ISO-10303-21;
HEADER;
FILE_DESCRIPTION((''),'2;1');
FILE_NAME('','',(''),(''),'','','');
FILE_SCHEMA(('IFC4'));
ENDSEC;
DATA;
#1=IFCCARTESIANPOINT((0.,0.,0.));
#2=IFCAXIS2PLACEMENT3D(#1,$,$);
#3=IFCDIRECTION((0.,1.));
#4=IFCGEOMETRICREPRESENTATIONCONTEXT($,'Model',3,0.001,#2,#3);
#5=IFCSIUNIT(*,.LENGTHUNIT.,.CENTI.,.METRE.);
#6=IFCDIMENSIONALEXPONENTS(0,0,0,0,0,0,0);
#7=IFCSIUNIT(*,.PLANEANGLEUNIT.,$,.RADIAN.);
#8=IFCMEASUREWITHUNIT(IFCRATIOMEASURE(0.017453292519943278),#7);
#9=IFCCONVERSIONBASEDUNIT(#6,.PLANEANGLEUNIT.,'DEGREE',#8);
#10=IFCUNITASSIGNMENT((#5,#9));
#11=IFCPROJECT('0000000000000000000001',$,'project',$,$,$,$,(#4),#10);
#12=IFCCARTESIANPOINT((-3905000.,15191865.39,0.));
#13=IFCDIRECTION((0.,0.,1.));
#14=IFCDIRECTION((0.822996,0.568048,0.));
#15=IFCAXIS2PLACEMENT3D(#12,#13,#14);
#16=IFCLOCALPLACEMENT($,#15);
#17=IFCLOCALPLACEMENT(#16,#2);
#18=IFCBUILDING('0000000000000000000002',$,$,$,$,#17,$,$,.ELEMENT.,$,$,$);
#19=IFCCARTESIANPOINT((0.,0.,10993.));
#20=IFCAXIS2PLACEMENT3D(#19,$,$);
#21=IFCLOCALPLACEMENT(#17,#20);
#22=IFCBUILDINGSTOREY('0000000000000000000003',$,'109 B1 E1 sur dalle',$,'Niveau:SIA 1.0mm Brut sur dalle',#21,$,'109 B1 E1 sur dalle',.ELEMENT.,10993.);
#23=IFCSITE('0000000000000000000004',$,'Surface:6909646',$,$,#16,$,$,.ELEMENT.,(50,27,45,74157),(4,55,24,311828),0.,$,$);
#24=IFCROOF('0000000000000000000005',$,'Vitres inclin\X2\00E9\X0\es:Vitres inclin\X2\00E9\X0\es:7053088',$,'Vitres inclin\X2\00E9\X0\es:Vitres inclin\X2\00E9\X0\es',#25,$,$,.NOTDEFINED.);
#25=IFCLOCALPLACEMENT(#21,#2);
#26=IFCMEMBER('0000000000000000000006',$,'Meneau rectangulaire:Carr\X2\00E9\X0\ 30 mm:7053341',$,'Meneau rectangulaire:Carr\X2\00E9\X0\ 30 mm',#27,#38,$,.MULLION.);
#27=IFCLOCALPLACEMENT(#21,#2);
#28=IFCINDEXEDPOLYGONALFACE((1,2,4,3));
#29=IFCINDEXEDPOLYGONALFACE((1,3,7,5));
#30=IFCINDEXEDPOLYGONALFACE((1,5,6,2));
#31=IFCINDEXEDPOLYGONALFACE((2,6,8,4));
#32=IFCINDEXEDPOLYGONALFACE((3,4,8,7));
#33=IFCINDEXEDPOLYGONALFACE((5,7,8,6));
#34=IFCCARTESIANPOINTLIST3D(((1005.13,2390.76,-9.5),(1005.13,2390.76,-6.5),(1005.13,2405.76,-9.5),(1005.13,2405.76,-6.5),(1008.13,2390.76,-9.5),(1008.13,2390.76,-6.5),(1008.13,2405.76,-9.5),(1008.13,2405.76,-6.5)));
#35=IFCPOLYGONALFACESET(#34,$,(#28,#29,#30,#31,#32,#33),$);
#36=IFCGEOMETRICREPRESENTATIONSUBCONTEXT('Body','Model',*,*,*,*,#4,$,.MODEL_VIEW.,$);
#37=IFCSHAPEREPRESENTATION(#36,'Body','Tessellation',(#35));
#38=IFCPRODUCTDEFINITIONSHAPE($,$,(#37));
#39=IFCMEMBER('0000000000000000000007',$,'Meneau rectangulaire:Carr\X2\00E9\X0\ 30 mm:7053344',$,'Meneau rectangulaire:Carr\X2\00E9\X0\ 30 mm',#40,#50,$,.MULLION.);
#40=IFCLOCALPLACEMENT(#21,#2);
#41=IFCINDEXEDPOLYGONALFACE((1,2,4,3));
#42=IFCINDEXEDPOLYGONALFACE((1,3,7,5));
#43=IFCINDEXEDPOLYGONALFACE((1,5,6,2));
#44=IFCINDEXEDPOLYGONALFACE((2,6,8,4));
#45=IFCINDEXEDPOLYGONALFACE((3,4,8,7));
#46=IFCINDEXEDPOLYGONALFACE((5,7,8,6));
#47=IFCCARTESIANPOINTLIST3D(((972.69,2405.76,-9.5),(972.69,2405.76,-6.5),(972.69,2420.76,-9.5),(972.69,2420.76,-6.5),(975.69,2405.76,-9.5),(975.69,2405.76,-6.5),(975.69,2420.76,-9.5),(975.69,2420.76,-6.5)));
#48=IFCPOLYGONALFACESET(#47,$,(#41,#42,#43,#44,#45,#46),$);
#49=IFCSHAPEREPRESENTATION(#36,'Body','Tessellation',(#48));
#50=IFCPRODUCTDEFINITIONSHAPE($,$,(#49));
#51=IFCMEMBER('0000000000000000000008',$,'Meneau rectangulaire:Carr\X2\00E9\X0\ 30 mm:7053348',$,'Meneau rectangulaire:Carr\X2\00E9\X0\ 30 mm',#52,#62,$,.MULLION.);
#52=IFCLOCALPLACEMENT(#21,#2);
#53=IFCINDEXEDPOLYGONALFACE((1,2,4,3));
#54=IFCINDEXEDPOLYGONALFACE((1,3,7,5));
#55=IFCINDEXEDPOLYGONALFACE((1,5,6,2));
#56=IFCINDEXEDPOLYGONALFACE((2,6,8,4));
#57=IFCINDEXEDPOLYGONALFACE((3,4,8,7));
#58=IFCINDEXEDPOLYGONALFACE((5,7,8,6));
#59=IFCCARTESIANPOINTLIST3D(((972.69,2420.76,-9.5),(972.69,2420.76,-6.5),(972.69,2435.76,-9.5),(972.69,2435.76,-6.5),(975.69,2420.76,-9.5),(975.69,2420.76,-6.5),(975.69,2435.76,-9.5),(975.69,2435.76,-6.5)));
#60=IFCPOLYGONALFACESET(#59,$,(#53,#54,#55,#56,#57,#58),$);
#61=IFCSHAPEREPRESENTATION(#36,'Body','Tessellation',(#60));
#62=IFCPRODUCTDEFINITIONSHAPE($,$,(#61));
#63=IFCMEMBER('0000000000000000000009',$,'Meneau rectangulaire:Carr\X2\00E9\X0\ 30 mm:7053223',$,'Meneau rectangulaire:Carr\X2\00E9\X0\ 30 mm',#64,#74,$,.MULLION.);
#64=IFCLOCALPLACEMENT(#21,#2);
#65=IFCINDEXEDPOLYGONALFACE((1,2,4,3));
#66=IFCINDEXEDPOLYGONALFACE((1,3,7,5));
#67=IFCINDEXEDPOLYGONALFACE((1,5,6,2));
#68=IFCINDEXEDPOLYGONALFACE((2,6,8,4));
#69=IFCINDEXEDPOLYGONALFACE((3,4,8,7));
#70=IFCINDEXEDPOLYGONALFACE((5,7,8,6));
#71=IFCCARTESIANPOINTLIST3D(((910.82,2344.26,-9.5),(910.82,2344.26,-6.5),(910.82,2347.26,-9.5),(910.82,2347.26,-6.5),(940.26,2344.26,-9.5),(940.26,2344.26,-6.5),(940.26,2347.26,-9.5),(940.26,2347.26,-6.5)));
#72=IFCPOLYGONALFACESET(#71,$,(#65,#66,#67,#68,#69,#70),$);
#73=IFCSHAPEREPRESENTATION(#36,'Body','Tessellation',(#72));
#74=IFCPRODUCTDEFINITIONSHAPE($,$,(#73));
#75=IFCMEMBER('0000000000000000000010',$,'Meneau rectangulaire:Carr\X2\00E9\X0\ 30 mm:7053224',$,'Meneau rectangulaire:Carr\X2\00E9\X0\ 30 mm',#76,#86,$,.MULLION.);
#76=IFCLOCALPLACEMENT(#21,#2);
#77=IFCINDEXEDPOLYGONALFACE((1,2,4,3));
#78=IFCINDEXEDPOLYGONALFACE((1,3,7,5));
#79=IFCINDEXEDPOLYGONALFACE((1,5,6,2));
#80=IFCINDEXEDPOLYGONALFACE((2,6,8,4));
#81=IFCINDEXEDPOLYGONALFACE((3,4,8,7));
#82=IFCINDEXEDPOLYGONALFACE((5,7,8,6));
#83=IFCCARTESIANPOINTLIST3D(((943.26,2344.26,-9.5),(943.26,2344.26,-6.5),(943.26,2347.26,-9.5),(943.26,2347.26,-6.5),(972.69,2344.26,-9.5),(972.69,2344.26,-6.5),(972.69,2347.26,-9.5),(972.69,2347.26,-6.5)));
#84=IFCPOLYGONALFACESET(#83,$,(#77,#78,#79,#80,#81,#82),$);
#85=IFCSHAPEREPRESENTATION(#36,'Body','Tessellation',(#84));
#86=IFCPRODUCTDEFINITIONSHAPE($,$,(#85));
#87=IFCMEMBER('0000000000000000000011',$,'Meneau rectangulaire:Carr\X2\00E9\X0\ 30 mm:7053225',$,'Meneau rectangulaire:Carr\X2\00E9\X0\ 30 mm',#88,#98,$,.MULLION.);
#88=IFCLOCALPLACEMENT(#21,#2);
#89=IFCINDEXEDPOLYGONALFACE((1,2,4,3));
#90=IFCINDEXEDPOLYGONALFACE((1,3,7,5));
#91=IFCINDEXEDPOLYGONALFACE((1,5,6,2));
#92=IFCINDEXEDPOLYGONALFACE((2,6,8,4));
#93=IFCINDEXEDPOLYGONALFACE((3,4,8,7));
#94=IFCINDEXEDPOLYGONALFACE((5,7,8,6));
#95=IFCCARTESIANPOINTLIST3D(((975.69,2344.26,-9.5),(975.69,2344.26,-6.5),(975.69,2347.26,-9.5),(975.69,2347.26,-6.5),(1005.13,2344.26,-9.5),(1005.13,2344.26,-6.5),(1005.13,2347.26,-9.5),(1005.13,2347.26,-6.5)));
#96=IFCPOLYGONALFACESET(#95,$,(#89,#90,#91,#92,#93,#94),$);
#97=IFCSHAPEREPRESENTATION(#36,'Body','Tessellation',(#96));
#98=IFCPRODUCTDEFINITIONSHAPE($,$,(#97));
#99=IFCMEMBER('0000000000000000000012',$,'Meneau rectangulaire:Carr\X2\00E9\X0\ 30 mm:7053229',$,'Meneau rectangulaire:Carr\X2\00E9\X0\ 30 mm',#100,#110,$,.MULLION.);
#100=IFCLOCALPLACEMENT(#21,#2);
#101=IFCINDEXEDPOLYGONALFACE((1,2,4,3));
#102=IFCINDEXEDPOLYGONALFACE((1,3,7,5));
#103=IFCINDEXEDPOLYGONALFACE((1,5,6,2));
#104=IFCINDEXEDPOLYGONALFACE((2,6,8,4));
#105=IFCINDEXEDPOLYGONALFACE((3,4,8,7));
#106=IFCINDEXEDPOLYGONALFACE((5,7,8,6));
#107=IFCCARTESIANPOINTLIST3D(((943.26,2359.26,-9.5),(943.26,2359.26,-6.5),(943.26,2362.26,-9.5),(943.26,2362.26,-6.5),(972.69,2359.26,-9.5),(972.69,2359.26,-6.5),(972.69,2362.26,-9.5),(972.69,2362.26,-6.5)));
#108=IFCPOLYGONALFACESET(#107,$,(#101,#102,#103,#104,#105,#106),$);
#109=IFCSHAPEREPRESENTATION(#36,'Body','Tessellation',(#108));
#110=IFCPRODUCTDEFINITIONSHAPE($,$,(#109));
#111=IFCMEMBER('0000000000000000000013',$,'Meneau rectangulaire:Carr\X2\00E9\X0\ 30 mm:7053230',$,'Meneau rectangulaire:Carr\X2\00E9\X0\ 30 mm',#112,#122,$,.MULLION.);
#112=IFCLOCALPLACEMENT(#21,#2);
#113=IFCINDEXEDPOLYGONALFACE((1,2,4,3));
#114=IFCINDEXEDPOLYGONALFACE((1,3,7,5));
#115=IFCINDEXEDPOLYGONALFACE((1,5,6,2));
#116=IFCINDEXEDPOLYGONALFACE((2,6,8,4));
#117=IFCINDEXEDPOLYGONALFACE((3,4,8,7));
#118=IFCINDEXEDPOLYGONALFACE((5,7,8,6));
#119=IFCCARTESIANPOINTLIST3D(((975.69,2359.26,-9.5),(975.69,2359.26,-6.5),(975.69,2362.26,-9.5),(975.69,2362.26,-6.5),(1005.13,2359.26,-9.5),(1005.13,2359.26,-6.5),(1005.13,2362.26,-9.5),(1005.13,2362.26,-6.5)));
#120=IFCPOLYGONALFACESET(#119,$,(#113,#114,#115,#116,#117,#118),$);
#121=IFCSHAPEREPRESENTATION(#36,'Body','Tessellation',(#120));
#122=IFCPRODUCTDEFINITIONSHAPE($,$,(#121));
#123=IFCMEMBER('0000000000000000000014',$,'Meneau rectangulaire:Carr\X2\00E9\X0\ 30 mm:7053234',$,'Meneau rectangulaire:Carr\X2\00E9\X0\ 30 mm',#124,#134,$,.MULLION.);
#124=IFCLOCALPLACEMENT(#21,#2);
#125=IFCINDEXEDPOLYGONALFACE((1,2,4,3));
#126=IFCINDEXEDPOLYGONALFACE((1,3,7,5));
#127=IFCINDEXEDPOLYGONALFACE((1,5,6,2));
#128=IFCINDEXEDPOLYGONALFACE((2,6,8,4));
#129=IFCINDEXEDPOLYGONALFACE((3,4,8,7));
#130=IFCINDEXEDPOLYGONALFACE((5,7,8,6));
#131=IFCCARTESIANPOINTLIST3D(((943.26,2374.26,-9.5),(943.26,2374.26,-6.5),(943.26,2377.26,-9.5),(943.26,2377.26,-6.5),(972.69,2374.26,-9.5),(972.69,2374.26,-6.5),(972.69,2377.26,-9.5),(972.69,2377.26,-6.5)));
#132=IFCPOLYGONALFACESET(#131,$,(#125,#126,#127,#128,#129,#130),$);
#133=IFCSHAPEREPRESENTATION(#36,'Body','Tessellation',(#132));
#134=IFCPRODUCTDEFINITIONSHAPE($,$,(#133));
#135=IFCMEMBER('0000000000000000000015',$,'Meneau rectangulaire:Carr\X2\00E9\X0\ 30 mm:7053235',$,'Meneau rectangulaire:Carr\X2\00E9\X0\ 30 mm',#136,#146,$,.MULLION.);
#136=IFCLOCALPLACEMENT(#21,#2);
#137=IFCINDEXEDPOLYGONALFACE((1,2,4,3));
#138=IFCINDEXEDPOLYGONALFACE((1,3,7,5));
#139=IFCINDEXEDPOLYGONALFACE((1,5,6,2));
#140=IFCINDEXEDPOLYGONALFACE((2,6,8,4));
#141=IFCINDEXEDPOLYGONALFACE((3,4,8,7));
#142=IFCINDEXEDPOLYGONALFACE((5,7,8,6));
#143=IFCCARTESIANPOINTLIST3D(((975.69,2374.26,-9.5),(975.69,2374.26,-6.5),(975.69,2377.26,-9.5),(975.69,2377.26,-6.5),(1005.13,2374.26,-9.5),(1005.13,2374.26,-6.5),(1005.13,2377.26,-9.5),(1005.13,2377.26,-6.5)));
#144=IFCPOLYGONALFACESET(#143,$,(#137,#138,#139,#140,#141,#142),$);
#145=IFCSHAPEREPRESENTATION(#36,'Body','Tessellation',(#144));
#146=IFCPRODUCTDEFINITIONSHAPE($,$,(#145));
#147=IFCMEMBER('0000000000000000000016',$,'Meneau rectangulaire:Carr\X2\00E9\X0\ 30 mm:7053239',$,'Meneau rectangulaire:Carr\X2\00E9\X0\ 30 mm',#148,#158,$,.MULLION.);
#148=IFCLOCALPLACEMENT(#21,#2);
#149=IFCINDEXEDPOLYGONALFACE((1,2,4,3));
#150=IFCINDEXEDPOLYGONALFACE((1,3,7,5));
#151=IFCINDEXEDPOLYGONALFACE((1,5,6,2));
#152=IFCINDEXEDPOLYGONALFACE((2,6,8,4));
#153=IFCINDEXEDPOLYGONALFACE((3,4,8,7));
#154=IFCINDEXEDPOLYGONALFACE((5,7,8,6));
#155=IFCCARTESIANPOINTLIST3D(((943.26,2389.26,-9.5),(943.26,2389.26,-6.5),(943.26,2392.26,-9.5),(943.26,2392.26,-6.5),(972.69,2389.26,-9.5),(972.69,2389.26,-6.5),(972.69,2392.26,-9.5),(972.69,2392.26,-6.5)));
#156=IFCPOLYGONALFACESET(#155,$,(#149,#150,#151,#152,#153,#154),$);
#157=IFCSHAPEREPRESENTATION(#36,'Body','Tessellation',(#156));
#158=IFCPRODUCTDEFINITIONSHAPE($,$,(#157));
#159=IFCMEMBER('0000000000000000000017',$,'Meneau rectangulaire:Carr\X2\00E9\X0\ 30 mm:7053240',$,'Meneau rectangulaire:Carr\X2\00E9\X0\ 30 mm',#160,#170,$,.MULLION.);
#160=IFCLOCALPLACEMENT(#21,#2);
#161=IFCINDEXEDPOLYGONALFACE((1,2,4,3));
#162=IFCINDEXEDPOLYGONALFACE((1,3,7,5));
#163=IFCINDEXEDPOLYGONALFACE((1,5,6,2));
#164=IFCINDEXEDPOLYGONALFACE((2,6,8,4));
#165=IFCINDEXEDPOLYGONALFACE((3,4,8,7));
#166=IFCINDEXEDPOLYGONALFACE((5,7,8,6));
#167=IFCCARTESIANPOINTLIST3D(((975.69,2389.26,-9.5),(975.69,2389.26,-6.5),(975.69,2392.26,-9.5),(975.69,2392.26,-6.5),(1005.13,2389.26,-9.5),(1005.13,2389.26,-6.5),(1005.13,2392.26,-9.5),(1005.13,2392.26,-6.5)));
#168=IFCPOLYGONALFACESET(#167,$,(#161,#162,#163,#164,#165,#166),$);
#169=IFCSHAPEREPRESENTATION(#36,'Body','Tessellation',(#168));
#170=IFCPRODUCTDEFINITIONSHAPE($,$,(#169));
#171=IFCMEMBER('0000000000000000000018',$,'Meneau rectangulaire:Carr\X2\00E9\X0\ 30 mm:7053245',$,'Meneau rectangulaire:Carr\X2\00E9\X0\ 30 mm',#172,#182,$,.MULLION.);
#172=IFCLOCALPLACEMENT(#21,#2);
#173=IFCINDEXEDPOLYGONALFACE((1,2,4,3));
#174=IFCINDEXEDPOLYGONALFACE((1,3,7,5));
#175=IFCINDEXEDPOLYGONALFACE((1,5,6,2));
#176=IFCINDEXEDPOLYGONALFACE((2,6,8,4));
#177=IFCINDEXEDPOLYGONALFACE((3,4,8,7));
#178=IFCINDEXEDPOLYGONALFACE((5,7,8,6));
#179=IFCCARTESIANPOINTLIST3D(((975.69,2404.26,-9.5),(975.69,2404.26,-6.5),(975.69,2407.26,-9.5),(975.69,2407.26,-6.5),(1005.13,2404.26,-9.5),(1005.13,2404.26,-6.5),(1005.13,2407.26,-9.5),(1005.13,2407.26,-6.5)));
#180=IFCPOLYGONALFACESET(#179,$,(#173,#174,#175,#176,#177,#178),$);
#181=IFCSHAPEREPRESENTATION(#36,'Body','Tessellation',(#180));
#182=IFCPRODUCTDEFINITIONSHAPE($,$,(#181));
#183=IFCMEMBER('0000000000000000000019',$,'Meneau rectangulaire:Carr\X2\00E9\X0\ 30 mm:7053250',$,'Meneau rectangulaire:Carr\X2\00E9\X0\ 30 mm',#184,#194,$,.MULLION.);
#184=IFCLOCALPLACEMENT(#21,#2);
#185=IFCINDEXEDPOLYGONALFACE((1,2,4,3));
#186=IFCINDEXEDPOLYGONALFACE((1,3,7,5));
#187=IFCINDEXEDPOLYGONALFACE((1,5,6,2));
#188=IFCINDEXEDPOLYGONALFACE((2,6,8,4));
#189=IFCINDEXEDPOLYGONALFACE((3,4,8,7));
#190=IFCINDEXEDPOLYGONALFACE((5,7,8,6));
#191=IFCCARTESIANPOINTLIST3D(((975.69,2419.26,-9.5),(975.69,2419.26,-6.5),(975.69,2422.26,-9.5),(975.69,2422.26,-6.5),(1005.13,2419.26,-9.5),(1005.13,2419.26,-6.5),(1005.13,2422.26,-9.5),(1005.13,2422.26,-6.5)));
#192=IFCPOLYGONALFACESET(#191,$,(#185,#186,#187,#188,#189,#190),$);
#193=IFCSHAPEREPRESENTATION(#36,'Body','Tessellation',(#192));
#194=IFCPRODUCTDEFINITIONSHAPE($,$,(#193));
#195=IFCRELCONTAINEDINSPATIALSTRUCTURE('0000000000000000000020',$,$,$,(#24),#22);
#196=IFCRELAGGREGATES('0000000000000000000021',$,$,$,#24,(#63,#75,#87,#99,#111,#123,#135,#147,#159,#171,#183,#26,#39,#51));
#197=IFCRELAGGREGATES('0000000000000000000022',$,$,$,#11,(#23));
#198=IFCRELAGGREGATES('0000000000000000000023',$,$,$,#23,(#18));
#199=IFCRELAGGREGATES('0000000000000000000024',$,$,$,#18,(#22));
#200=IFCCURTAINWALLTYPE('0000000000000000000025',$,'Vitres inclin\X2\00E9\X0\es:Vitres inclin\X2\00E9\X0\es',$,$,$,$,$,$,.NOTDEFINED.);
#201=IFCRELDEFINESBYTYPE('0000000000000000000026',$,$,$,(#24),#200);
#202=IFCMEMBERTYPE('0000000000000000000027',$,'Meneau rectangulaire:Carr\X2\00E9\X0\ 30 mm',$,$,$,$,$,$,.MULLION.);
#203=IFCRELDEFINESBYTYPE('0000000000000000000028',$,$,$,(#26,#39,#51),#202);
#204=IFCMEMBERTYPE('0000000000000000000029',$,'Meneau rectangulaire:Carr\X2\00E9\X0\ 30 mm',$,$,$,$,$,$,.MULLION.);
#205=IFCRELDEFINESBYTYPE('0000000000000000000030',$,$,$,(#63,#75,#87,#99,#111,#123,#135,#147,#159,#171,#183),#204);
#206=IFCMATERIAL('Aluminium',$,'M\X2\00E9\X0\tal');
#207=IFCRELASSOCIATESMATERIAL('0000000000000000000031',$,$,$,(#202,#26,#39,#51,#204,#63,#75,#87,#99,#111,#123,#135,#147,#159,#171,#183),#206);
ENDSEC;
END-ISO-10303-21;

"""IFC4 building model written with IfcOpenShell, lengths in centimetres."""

from ifc_helpers import new_model, entity, si_unit, converted_unit, direction, frame, origin, place, context, subcontext, project, spatial, indexed_curve, outline, extrude, source, transform, mapped, material, type_object, type_shapes, element, aggregate, save


model = new_model("IFC4")

# Units and contexts
model_context = context("Model", 3, precision=0.001, world=origin(), true_north=direction((0.0, 1.0)))
body_context = subcontext(model_context, "Body", "Model", "MODEL_VIEW")
ifc_project = project(units=[si_unit("LENGTHUNIT", "METRE", prefix="CENTI"), converted_unit("PLANEANGLEUNIT", "DEGREE", entity("IfcRatioMeasure", 0.017453292519943278), si_unit("PLANEANGLEUNIT", "RADIAN"), dimensions=[0, 0, 0, 0, 0, 0, 0])], contexts=[model_context])

# Site, building, storey
site_placement = place(None, frame((-3905000.0, 15191865.39, 0.0), z_axis=(0.0, 0.0, 1.0), x_axis=(0.822996, 0.568048, 0.0)))
site = spatial("IfcSite", under=ifc_project, at=site_placement, Name="Surface:6909646", CompositionType="ELEMENT", RefLatitude=(50, 27, 45, 74157), RefLongitude=(4, 55, 24, 311828), RefElevation=0.0)
building_placement = place(site_placement, origin())
building = spatial("IfcBuilding", under=site, at=building_placement, CompositionType="ELEMENT")
storey_placement = place(building_placement, frame((0.0, 0.0, 10993.0)))
storey = spatial("IfcBuildingStorey", under=building, at=storey_placement, Name="109 B1 E1 sur dalle", ObjectType="Niveau:SIA 1.0mm Brut sur dalle", LongName="109 B1 E1 sur dalle", CompositionType="ELEMENT", Elevation=10993.0)

# Roof, members
curtain_wall_type = type_object("IfcCurtainWallType", Name="Vitres inclinées:Vitres inclinées", PredefinedType="NOTDEFINED")
roof_placement = place(storey_placement, frame((0.0, 0.0, -10993.0)))
roof = element("IfcRoof", 1, at=roof_placement, inside=storey, type_object=curtain_wall_type, Name="Vitres inclinées:Vitres inclinées:7053088", ObjectType="Vitres inclinées:Vitres inclinées", PredefinedType="NOTDEFINED")
ifc_material = material(Name="Aluminium", Category="Métal")
member_type_1 = type_object("IfcMemberType", Name="Meneau rectangulaire:Carré 30 mm", PredefinedType="MULLION", material=ifc_material)
shared_shape_1 = source(origin(), body_context, "Body", "SweptSolid", [
    extrude(outline(indexed_curve([(-1.5, -1.5), (1.5, -1.5), (1.5, 1.5), (-1.5, 1.5), (-1.5, -1.5)], self_intersect=False)), frame((0.0, 0.0, -15.0), z_axis=(0.0, 0.0, 1.0), x_axis=(0.0, -1.0, 0.0)), (0.0, 0.0, 1.0), 15.0),
])
type_shapes(member_type_1, [shared_shape_1])
member_1_placement = place(roof_placement, frame((1006.63, 2405.76, 10985.0), z_axis=(0.0, 1.0, 0.0), x_axis=(1.0, 0.0, 0.0)))
member_1 = element("IfcMember", 2, at=member_1_placement, type_object=member_type_1, material=ifc_material, Name="Meneau rectangulaire:Carré 30 mm:7053341", ObjectType="Meneau rectangulaire:Carré 30 mm", PredefinedType="MULLION", context=body_context, shape_type="MappedRepresentation", body=[
    mapped(shared_shape_1, transform((0.0, 0.0, 0.0), scale=1.0)),
])
member_2_placement = place(roof_placement, frame((974.19, 2420.76, 10985.0), z_axis=(0.0, 1.0, 0.0), x_axis=(1.0, 0.0, 0.0)))
member_2 = element("IfcMember", 3, at=member_2_placement, type_object=member_type_1, material=ifc_material, Name="Meneau rectangulaire:Carré 30 mm:7053344", ObjectType="Meneau rectangulaire:Carré 30 mm", PredefinedType="MULLION", context=body_context, shape_type="MappedRepresentation", body=[
    mapped(shared_shape_1, transform((0.0, 0.0, 0.0), scale=1.0)),
])
member_3_placement = place(roof_placement, frame((974.19, 2435.76, 10985.0), z_axis=(0.0, 1.0, 0.0), x_axis=(1.0, 0.0, 0.0)))
member_3 = element("IfcMember", 4, at=member_3_placement, type_object=member_type_1, material=ifc_material, Name="Meneau rectangulaire:Carré 30 mm:7053348", ObjectType="Meneau rectangulaire:Carré 30 mm", PredefinedType="MULLION", context=body_context, shape_type="MappedRepresentation", body=[
    mapped(shared_shape_1, transform((0.0, 0.0, 0.0), scale=1.0)),
])
member_type_2 = type_object("IfcMemberType", Name="Meneau rectangulaire:Carré 30 mm", PredefinedType="MULLION", material=ifc_material)
shared_shape_2 = source(origin(), body_context, "Body", "SweptSolid", [
    extrude(outline(indexed_curve([(-1.5, -1.5), (1.5, -1.5), (1.5, 1.5), (-1.5, 1.5), (-1.5, -1.5)], self_intersect=False)), frame((0.0, 0.0, -29.44), z_axis=(0.0, 0.0, 1.0), x_axis=(0.0, -1.0, 0.0)), (0.0, 0.0, 1.0), 29.44),
])
type_shapes(member_type_2, [shared_shape_2])
member_4_placement = place(roof_placement, frame((910.82, 2345.76, 10985.0), z_axis=(-1.0, 0.0, 0.0), x_axis=(0.0, 1.0, 0.0)))
member_4 = element("IfcMember", 5, at=member_4_placement, type_object=member_type_2, material=ifc_material, Name="Meneau rectangulaire:Carré 30 mm:7053223", ObjectType="Meneau rectangulaire:Carré 30 mm", PredefinedType="MULLION", context=body_context, shape_type="MappedRepresentation", body=[
    mapped(shared_shape_2, transform((0.0, 0.0, 0.0), scale=1.0)),
])
member_5_placement = place(roof_placement, frame((943.26, 2345.76, 10985.0), z_axis=(-1.0, 0.0, 0.0), x_axis=(0.0, 1.0, 0.0)))
member_5 = element("IfcMember", 6, at=member_5_placement, type_object=member_type_2, material=ifc_material, Name="Meneau rectangulaire:Carré 30 mm:7053224", ObjectType="Meneau rectangulaire:Carré 30 mm", PredefinedType="MULLION", context=body_context, shape_type="MappedRepresentation", body=[
    mapped(shared_shape_2, transform((0.0, 0.0, 0.0), scale=1.0)),
])
member_6_placement = place(roof_placement, frame((975.69, 2345.76, 10985.0), z_axis=(-1.0, 0.0, 0.0), x_axis=(0.0, 1.0, 0.0)))
member_6 = element("IfcMember", 7, at=member_6_placement, type_object=member_type_2, material=ifc_material, Name="Meneau rectangulaire:Carré 30 mm:7053225", ObjectType="Meneau rectangulaire:Carré 30 mm", PredefinedType="MULLION", context=body_context, shape_type="MappedRepresentation", body=[
    mapped(shared_shape_2, transform((0.0, 0.0, 0.0), scale=1.0)),
])
member_7_placement = place(roof_placement, frame((943.26, 2360.76, 10985.0), z_axis=(-1.0, 0.0, 0.0), x_axis=(0.0, 1.0, 0.0)))
member_7 = element("IfcMember", 8, at=member_7_placement, type_object=member_type_2, material=ifc_material, Name="Meneau rectangulaire:Carré 30 mm:7053229", ObjectType="Meneau rectangulaire:Carré 30 mm", PredefinedType="MULLION", context=body_context, shape_type="MappedRepresentation", body=[
    mapped(shared_shape_2, transform((0.0, 0.0, 0.0), scale=1.0)),
])
member_8_placement = place(roof_placement, frame((975.69, 2360.76, 10985.0), z_axis=(-1.0, 0.0, 0.0), x_axis=(0.0, 1.0, 0.0)))
member_8 = element("IfcMember", 9, at=member_8_placement, type_object=member_type_2, material=ifc_material, Name="Meneau rectangulaire:Carré 30 mm:7053230", ObjectType="Meneau rectangulaire:Carré 30 mm", PredefinedType="MULLION", context=body_context, shape_type="MappedRepresentation", body=[
    mapped(shared_shape_2, transform((0.0, 0.0, 0.0), scale=1.0)),
])
member_9_placement = place(roof_placement, frame((943.26, 2375.76, 10985.0), z_axis=(-1.0, 0.0, 0.0), x_axis=(0.0, 1.0, 0.0)))
member_9 = element("IfcMember", 10, at=member_9_placement, type_object=member_type_2, material=ifc_material, Name="Meneau rectangulaire:Carré 30 mm:7053234", ObjectType="Meneau rectangulaire:Carré 30 mm", PredefinedType="MULLION", context=body_context, shape_type="MappedRepresentation", body=[
    mapped(shared_shape_2, transform((0.0, 0.0, 0.0), scale=1.0)),
])
member_10_placement = place(roof_placement, frame((975.69, 2375.76, 10985.0), z_axis=(-1.0, 0.0, 0.0), x_axis=(0.0, 1.0, 0.0)))
member_10 = element("IfcMember", 11, at=member_10_placement, type_object=member_type_2, material=ifc_material, Name="Meneau rectangulaire:Carré 30 mm:7053235", ObjectType="Meneau rectangulaire:Carré 30 mm", PredefinedType="MULLION", context=body_context, shape_type="MappedRepresentation", body=[
    mapped(shared_shape_2, transform((0.0, 0.0, 0.0), scale=1.0)),
])
member_11_placement = place(roof_placement, frame((943.26, 2390.76, 10985.0), z_axis=(-1.0, 0.0, 0.0), x_axis=(0.0, 1.0, 0.0)))
member_11 = element("IfcMember", 12, at=member_11_placement, type_object=member_type_2, material=ifc_material, Name="Meneau rectangulaire:Carré 30 mm:7053239", ObjectType="Meneau rectangulaire:Carré 30 mm", PredefinedType="MULLION", context=body_context, shape_type="MappedRepresentation", body=[
    mapped(shared_shape_2, transform((0.0, 0.0, 0.0), scale=1.0)),
])
member_12_placement = place(roof_placement, frame((975.69, 2390.76, 10985.0), z_axis=(-1.0, 0.0, 0.0), x_axis=(0.0, 1.0, 0.0)))
member_12 = element("IfcMember", 13, at=member_12_placement, type_object=member_type_2, material=ifc_material, Name="Meneau rectangulaire:Carré 30 mm:7053240", ObjectType="Meneau rectangulaire:Carré 30 mm", PredefinedType="MULLION", context=body_context, shape_type="MappedRepresentation", body=[
    mapped(shared_shape_2, transform((0.0, 0.0, 0.0), scale=1.0)),
])
member_13_placement = place(roof_placement, frame((975.69, 2405.76, 10985.0), z_axis=(-1.0, 0.0, 0.0), x_axis=(0.0, 1.0, 0.0)))
member_13 = element("IfcMember", 14, at=member_13_placement, type_object=member_type_2, material=ifc_material, Name="Meneau rectangulaire:Carré 30 mm:7053245", ObjectType="Meneau rectangulaire:Carré 30 mm", PredefinedType="MULLION", context=body_context, shape_type="MappedRepresentation", body=[
    mapped(shared_shape_2, transform((0.0, 0.0, 0.0), scale=1.0)),
])
member_14_placement = place(roof_placement, frame((975.69, 2420.76, 10985.0), z_axis=(-1.0, 0.0, 0.0), x_axis=(0.0, 1.0, 0.0)))
member_14 = element("IfcMember", 15, at=member_14_placement, type_object=member_type_2, material=ifc_material, Name="Meneau rectangulaire:Carré 30 mm:7053250", ObjectType="Meneau rectangulaire:Carré 30 mm", PredefinedType="MULLION", context=body_context, shape_type="MappedRepresentation", body=[
    mapped(shared_shape_2, transform((0.0, 0.0, 0.0), scale=1.0)),
])
aggregate(roof, [member_4, member_5, member_6, member_7, member_8, member_9, member_10, member_11, member_12, member_13, member_14, member_1, member_2, member_3])

save(model, "model.ifc")
